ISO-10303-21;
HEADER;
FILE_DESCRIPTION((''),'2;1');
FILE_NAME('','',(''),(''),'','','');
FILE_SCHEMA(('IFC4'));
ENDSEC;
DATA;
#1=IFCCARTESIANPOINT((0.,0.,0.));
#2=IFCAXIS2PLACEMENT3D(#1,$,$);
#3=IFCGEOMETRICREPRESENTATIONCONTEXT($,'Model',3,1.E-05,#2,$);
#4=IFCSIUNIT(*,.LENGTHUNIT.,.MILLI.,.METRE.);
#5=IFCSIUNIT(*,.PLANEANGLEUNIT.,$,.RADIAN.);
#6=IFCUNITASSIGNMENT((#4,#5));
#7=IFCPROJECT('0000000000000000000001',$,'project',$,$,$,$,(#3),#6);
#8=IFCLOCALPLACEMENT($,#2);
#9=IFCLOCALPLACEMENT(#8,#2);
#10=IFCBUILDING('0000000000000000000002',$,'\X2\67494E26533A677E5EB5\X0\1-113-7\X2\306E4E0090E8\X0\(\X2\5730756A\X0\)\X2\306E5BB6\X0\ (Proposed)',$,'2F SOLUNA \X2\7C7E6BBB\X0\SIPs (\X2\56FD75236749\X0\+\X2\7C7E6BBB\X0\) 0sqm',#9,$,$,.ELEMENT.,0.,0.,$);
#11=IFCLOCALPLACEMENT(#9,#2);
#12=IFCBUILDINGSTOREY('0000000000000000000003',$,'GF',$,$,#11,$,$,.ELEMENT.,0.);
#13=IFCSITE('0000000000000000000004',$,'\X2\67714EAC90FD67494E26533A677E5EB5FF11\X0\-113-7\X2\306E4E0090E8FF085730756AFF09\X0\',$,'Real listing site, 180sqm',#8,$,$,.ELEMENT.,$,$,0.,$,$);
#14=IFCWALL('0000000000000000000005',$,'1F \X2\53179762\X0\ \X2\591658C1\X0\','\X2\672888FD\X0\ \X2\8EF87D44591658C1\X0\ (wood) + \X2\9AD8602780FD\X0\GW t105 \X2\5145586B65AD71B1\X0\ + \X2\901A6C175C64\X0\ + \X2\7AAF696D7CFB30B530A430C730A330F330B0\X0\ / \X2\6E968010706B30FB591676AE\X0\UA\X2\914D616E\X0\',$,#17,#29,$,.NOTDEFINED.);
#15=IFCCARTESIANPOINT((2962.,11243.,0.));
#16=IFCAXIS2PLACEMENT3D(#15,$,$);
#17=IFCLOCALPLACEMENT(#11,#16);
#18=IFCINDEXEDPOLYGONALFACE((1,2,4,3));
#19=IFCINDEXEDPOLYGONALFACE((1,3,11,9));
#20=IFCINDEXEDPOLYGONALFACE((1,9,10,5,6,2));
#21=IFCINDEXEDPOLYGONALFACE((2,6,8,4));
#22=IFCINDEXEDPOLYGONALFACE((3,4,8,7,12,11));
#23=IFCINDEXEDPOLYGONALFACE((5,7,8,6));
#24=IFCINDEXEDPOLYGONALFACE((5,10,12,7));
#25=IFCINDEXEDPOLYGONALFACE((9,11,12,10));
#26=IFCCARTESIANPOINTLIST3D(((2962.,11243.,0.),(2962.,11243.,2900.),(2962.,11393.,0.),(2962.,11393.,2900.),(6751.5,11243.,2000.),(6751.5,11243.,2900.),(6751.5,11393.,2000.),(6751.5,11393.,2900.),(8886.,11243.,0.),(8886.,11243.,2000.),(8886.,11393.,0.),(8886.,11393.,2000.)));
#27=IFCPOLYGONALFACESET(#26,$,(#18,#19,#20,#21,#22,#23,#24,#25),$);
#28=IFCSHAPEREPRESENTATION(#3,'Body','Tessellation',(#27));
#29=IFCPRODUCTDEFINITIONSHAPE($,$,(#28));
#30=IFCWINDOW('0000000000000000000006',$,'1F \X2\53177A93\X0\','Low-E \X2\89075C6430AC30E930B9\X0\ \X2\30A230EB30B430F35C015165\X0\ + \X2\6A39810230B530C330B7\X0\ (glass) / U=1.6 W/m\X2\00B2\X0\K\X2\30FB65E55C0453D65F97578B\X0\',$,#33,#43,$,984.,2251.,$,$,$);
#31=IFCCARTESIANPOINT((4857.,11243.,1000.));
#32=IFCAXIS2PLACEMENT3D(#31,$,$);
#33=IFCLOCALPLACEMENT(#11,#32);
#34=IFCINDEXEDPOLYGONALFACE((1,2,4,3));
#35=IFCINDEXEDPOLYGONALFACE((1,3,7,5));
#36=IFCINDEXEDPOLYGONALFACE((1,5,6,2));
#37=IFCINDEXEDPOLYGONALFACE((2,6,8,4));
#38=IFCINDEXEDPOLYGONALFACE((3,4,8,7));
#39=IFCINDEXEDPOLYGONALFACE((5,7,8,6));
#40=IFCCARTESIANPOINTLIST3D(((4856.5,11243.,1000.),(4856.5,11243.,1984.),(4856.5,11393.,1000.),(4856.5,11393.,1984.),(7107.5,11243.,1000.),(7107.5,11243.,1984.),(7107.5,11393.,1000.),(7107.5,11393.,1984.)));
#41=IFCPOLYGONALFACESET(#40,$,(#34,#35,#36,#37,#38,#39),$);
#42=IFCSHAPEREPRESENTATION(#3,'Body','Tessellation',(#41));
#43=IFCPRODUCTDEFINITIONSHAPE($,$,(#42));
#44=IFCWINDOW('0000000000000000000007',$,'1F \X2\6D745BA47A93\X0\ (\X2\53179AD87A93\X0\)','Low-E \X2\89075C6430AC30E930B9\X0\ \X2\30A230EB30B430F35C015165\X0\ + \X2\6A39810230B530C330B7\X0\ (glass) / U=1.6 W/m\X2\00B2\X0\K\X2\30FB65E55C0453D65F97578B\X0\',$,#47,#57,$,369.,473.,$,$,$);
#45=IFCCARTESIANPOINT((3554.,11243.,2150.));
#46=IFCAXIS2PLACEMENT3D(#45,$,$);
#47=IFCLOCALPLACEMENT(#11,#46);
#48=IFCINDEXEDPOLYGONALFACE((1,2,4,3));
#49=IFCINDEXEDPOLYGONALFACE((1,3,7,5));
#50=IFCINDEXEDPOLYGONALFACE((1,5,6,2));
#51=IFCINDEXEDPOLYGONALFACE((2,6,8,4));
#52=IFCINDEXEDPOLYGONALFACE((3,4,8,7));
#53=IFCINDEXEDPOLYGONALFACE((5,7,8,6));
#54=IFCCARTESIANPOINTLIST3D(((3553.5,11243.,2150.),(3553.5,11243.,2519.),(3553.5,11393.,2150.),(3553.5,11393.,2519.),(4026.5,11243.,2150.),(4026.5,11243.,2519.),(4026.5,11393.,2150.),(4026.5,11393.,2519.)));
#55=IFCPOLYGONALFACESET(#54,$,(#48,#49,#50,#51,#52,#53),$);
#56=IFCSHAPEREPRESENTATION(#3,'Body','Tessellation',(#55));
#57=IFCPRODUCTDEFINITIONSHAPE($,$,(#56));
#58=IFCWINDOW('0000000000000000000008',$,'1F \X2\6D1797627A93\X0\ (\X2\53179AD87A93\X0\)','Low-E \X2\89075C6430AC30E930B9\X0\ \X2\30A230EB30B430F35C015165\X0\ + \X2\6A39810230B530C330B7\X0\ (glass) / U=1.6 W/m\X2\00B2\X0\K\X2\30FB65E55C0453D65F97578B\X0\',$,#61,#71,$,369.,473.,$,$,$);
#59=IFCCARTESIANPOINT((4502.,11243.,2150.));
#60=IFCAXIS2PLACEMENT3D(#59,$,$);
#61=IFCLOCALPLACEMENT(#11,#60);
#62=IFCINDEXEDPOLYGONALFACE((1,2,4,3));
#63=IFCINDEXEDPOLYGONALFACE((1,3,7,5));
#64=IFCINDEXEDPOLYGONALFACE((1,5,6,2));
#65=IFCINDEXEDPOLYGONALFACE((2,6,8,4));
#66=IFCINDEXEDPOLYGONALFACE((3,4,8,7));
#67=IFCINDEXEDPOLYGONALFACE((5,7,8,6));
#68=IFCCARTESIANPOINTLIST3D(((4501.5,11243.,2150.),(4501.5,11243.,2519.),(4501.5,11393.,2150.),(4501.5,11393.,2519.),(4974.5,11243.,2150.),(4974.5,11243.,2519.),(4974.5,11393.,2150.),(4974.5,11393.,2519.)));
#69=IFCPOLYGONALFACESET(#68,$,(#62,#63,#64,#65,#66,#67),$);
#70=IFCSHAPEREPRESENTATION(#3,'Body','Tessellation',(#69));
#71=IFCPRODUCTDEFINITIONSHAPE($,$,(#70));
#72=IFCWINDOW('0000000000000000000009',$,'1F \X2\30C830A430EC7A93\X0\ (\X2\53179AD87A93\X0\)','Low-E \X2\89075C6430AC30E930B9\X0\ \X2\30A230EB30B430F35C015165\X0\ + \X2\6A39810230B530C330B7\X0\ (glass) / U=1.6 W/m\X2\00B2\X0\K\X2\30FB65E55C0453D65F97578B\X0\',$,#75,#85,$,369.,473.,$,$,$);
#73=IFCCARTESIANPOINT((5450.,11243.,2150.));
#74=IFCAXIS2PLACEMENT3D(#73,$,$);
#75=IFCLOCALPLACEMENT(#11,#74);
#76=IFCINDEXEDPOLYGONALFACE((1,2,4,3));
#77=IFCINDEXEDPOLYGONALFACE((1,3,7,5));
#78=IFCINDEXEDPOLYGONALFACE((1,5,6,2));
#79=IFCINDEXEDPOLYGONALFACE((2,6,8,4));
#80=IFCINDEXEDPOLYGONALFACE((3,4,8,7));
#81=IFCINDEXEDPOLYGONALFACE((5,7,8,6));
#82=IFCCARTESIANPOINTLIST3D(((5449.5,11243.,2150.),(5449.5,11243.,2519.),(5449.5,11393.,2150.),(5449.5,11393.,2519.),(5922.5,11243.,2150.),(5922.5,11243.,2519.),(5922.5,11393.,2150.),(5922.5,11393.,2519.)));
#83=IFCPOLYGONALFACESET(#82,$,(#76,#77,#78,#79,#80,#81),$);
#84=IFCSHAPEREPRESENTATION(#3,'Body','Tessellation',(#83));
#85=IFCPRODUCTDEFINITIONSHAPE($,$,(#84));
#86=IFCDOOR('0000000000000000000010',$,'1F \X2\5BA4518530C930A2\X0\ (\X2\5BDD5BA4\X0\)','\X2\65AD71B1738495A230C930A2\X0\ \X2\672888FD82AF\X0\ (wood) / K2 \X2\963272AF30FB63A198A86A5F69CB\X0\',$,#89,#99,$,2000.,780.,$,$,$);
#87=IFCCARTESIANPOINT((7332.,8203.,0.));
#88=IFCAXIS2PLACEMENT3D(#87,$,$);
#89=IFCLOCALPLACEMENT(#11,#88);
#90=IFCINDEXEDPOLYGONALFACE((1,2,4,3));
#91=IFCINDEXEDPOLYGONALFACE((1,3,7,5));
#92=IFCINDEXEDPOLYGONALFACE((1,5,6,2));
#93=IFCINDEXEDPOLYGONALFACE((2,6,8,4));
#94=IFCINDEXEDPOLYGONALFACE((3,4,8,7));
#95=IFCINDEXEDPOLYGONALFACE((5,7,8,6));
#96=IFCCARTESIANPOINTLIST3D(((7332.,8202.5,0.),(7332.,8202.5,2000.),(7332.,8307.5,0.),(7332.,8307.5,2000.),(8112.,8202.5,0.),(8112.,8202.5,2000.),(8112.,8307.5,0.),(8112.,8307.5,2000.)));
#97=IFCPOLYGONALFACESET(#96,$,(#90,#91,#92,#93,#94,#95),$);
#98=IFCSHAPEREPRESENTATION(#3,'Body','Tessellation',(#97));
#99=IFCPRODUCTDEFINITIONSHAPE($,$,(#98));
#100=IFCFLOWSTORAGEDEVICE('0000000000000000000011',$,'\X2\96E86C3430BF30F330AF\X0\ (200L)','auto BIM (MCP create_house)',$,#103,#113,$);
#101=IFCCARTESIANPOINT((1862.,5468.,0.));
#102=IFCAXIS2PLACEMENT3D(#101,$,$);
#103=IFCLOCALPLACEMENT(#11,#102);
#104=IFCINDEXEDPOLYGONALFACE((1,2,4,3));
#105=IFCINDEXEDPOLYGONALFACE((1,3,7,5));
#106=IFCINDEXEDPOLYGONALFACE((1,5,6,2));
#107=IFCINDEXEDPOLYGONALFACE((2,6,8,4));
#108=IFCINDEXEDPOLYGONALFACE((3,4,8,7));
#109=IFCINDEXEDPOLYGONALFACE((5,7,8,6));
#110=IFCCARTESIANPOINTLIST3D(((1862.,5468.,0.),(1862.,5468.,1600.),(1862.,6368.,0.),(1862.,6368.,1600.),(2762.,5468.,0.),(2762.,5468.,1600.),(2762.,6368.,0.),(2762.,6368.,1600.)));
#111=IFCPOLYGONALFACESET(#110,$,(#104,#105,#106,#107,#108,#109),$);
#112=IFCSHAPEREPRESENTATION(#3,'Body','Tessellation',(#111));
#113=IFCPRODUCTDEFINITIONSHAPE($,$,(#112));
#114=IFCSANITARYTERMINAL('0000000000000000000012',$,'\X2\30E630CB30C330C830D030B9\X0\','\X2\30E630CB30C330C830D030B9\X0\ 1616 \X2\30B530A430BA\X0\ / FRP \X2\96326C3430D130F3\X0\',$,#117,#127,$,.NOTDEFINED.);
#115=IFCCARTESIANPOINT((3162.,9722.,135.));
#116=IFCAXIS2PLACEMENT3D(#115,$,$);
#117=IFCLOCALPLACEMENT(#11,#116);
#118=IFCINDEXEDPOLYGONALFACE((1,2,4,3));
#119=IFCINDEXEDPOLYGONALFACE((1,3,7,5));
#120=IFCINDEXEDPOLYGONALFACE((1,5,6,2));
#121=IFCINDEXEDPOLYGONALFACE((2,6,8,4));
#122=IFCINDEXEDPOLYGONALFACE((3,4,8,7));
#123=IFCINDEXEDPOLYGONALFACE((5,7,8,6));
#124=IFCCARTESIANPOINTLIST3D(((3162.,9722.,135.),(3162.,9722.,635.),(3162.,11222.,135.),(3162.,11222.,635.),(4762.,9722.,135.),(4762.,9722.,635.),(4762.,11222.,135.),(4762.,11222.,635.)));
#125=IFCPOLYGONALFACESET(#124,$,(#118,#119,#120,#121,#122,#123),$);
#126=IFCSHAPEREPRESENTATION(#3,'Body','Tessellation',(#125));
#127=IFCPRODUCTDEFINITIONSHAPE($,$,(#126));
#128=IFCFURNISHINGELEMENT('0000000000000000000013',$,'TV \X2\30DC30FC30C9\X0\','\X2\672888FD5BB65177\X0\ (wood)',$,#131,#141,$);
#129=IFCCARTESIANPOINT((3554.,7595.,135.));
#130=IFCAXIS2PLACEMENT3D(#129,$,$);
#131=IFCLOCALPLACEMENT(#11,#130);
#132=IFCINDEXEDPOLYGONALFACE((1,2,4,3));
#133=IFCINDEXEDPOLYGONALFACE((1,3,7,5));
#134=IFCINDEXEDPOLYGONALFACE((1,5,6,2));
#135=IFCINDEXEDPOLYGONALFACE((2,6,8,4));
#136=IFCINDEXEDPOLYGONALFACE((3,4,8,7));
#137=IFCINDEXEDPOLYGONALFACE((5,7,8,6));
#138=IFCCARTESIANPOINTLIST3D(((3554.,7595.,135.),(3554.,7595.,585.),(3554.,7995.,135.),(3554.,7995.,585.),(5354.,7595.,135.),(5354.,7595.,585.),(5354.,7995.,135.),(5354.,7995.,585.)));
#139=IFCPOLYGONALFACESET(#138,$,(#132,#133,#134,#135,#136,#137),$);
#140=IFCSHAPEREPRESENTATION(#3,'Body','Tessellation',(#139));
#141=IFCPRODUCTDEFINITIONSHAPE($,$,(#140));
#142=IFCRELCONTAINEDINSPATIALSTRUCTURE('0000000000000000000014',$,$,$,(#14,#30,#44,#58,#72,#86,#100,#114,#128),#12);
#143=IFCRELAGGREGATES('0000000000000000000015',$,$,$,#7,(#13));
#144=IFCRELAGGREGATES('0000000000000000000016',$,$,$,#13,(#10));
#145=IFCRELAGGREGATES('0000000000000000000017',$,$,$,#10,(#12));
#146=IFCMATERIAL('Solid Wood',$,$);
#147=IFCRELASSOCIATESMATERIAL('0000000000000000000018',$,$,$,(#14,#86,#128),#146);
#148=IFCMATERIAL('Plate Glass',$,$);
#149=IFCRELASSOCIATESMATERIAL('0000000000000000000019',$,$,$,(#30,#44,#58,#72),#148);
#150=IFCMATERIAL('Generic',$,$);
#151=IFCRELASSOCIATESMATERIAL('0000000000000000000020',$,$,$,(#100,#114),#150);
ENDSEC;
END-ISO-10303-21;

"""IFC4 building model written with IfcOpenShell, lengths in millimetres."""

from ifc_helpers import new_model, si_unit, frame, frame_2d, origin, place, context, project, spatial, rectangle, extrude, material, element, fill, save


model = new_model("IFC4")

# Units and contexts
model_context = context("Model", 3, precision=1e-05, world=origin())
ifc_project = project(units=[si_unit("LENGTHUNIT", "METRE", prefix="MILLI"), si_unit("PLANEANGLEUNIT", "RADIAN")], contexts=[model_context])

# Site, building, storey
site_placement = place(None, origin())
site = spatial("IfcSite", under=ifc_project, at=site_placement, Name="東京都杉並区松庵１-113-7の一部（地番）", ObjectType="Real listing site, 180sqm", CompositionType="ELEMENT", RefElevation=0.0)
building_placement = place(site_placement, origin())
building = spatial("IfcBuilding", under=site, at=building_placement, Name="杉並区松庵1-113-7の一部(地番)の家 (Proposed)", ObjectType="2F SOLUNA 籾殻SIPs (国産杉+籾殻) 0sqm", CompositionType="ELEMENT", ElevationOfRefHeight=0.0, ElevationOfTerrain=0.0)
storey_placement = place(building_placement, origin())
storey = spatial("IfcBuildingStorey", under=building, at=storey_placement, Name="GF", CompositionType="ELEMENT", Elevation=0.0)

# Wall, openings, windows
ifc_material_1 = material(Name="Solid Wood")
wall_1_placement = place(storey_placement, frame((2962.0, 11243.0, 0.0)))
wall_1 = element("IfcWall", 1, at=wall_1_placement, inside=storey, material=ifc_material_1, Name="1F 北面 外壁", Description="木製 軸組外壁 (wood) + 高性能GW t105 充填断熱 + 通気層 + 窯業系サイディング / 準耐火・外皮UA配慮", PredefinedType="NOTDEFINED", context=model_context, shape_type="SweptSolid", body=[
    extrude(rectangle(XDim=5924.0, YDim=150.0, at=frame_2d((2962.0, 75.0))), frame((2962.0, 11243.0, 0.0)), (0.0, 0.0, 1.0), 2900.0),
])
opening_1_placement = place(storey_placement, frame((4857.0, 11243.0, 1000.0)))
opening_1 = element("IfcOpeningElement", 2, at=opening_1_placement, cuts=wall_1, PredefinedType="NOTDEFINED", context=model_context, shape_type="SweptSolid", body=[
    extrude(rectangle(XDim=2251.0, YDim=150.0, at=frame_2d((1125.0, 75.0))), frame((4857.0, 11243.0, 1000.0)), (0.0, 0.0, 1.0), 984.0),
])
opening_2_placement = place(storey_placement, frame((3554.0, 11243.0, 2150.0)))
opening_2 = element("IfcOpeningElement", 3, at=opening_2_placement, cuts=wall_1, PredefinedType="NOTDEFINED", context=model_context, shape_type="SweptSolid", body=[
    extrude(rectangle(XDim=473.0, YDim=150.0, at=frame_2d((236.0, 75.0))), frame((3554.0, 11243.0, 2150.0)), (0.0, 0.0, 1.0), 369.0),
])
opening_3_placement = place(storey_placement, frame((4502.0, 11243.0, 2150.0)))
opening_3 = element("IfcOpeningElement", 4, at=opening_3_placement, cuts=wall_1, PredefinedType="NOTDEFINED", context=model_context, shape_type="SweptSolid", body=[
    extrude(rectangle(XDim=473.0, YDim=150.0, at=frame_2d((236.0, 75.0))), frame((4502.0, 11243.0, 2150.0)), (0.0, 0.0, 1.0), 369.0),
])
opening_4_placement = place(storey_placement, frame((5450.0, 11243.0, 2150.0)))
opening_4 = element("IfcOpeningElement", 5, at=opening_4_placement, cuts=wall_1, PredefinedType="NOTDEFINED", context=model_context, shape_type="SweptSolid", body=[
    extrude(rectangle(XDim=473.0, YDim=150.0, at=frame_2d((236.0, 75.0))), frame((5450.0, 11243.0, 2150.0)), (0.0, 0.0, 1.0), 369.0),
])
ifc_material_2 = material(Name="Plate Glass")
window_1_placement = place(storey_placement, frame((4857.0, 11243.0, 1000.0)))
window_1 = element("IfcWindow", 6, at=window_1_placement, inside=storey, material=ifc_material_2, Name="1F 北窓", Description="Low-E 複層ガラス アルゴン封入 + 樹脂サッシ (glass) / U=1.6 W/m²K・日射取得型", OverallHeight=984.0, OverallWidth=2251.0, context=model_context, shape_type="SweptSolid", body=[
    extrude(rectangle(XDim=2251.0, YDim=150.0, at=frame_2d((1125.0, 75.0))), frame((4857.0, 11243.0, 1000.0)), (0.0, 0.0, 1.0), 984.0),
])
fill(opening_1, window_1)
window_2_placement = place(storey_placement, frame((3554.0, 11243.0, 2150.0)))
window_2 = element("IfcWindow", 7, at=window_2_placement, inside=storey, material=ifc_material_2, Name="1F 浴室窓 (北高窓)", Description="Low-E 複層ガラス アルゴン封入 + 樹脂サッシ (glass) / U=1.6 W/m²K・日射取得型", OverallHeight=369.0, OverallWidth=473.0, context=model_context, shape_type="SweptSolid", body=[
    extrude(rectangle(XDim=473.0, YDim=150.0, at=frame_2d((236.0, 75.0))), frame((3554.0, 11243.0, 2150.0)), (0.0, 0.0, 1.0), 369.0),
])
fill(opening_2, window_2)
window_3_placement = place(storey_placement, frame((4502.0, 11243.0, 2150.0)))
window_3 = element("IfcWindow", 8, at=window_3_placement, inside=storey, material=ifc_material_2, Name="1F 洗面窓 (北高窓)", Description="Low-E 複層ガラス アルゴン封入 + 樹脂サッシ (glass) / U=1.6 W/m²K・日射取得型", OverallHeight=369.0, OverallWidth=473.0, context=model_context, shape_type="SweptSolid", body=[
    extrude(rectangle(XDim=473.0, YDim=150.0, at=frame_2d((236.0, 75.0))), frame((4502.0, 11243.0, 2150.0)), (0.0, 0.0, 1.0), 369.0),
])
fill(opening_3, window_3)
window_4_placement = place(storey_placement, frame((5450.0, 11243.0, 2150.0)))
window_4 = element("IfcWindow", 9, at=window_4_placement, inside=storey, material=ifc_material_2, Name="1F トイレ窓 (北高窓)", Description="Low-E 複層ガラス アルゴン封入 + 樹脂サッシ (glass) / U=1.6 W/m²K・日射取得型", OverallHeight=369.0, OverallWidth=473.0, context=model_context, shape_type="SweptSolid", body=[
    extrude(rectangle(XDim=473.0, YDim=150.0, at=frame_2d((236.0, 75.0))), frame((5450.0, 11243.0, 2150.0)), (0.0, 0.0, 1.0), 369.0),
])
fill(opening_4, window_4)

# Door
door_1_placement = place(storey_placement, frame((7332.0, 8203.0, 0.0)))
element("IfcDoor", 10, at=door_1_placement, inside=storey, material=ifc_material_1, Name="1F 室内ドア (寝室)", Description="断熱玄関ドア 木製芯 (wood) / K2 防犯・採風機構", OverallHeight=2000.0, OverallWidth=780.0, context=model_context, shape_type="SweptSolid", body=[
    extrude(rectangle(XDim=780.0, YDim=105.0, at=frame_2d((390.0, 52.0))), frame((7332.0, 8203.0, 0.0)), (0.0, 0.0, 1.0), 2000.0),
])

# Flow storage device
ifc_material_3 = material(Name="Generic")
flow_storage_device_placement = place(storey_placement, frame((1862.0, 5468.0, 0.0)))
element("IfcFlowStorageDevice", 11, at=flow_storage_device_placement, inside=storey, material=ifc_material_3, Name="雨水タンク (200L)", Description="auto BIM (MCP create_house)", context=model_context, shape_type="SweptSolid", body=[
    extrude(rectangle(XDim=900.0, YDim=900.0, at=frame_2d((450.0, 450.0))), frame((1862.0, 5468.0, 0.0)), (0.0, 0.0, 1.0), 1600.0),
])

# Sanitary terminal
sanitary_terminal_placement = place(storey_placement, frame((3162.0, 9722.0, 135.0)))
element("IfcSanitaryTerminal", 12, at=sanitary_terminal_placement, inside=storey, material=ifc_material_3, Name="ユニットバス", Description="ユニットバス 1616 サイズ / FRP 防水パン", PredefinedType="NOTDEFINED", context=model_context, shape_type="SweptSolid", body=[
    extrude(rectangle(XDim=1600.0, YDim=1500.0, at=frame_2d((800.0, 750.0))), frame((3162.0, 9722.0, 135.0)), (0.0, 0.0, 1.0), 500.0),
])

# Furnishing element
furnishing_placement = place(storey_placement, frame((3554.0, 7595.0, 135.0)))
element("IfcFurnishingElement", 13, at=furnishing_placement, inside=storey, material=ifc_material_1, Name="TV ボード", Description="木製家具 (wood)", context=model_context, shape_type="SweptSolid", body=[
    extrude(rectangle(XDim=1800.0, YDim=400.0, at=frame_2d((900.0, 200.0))), frame((3554.0, 7595.0, 135.0)), (0.0, 0.0, 1.0), 450.0),
])

save(model, "model.ifc")
